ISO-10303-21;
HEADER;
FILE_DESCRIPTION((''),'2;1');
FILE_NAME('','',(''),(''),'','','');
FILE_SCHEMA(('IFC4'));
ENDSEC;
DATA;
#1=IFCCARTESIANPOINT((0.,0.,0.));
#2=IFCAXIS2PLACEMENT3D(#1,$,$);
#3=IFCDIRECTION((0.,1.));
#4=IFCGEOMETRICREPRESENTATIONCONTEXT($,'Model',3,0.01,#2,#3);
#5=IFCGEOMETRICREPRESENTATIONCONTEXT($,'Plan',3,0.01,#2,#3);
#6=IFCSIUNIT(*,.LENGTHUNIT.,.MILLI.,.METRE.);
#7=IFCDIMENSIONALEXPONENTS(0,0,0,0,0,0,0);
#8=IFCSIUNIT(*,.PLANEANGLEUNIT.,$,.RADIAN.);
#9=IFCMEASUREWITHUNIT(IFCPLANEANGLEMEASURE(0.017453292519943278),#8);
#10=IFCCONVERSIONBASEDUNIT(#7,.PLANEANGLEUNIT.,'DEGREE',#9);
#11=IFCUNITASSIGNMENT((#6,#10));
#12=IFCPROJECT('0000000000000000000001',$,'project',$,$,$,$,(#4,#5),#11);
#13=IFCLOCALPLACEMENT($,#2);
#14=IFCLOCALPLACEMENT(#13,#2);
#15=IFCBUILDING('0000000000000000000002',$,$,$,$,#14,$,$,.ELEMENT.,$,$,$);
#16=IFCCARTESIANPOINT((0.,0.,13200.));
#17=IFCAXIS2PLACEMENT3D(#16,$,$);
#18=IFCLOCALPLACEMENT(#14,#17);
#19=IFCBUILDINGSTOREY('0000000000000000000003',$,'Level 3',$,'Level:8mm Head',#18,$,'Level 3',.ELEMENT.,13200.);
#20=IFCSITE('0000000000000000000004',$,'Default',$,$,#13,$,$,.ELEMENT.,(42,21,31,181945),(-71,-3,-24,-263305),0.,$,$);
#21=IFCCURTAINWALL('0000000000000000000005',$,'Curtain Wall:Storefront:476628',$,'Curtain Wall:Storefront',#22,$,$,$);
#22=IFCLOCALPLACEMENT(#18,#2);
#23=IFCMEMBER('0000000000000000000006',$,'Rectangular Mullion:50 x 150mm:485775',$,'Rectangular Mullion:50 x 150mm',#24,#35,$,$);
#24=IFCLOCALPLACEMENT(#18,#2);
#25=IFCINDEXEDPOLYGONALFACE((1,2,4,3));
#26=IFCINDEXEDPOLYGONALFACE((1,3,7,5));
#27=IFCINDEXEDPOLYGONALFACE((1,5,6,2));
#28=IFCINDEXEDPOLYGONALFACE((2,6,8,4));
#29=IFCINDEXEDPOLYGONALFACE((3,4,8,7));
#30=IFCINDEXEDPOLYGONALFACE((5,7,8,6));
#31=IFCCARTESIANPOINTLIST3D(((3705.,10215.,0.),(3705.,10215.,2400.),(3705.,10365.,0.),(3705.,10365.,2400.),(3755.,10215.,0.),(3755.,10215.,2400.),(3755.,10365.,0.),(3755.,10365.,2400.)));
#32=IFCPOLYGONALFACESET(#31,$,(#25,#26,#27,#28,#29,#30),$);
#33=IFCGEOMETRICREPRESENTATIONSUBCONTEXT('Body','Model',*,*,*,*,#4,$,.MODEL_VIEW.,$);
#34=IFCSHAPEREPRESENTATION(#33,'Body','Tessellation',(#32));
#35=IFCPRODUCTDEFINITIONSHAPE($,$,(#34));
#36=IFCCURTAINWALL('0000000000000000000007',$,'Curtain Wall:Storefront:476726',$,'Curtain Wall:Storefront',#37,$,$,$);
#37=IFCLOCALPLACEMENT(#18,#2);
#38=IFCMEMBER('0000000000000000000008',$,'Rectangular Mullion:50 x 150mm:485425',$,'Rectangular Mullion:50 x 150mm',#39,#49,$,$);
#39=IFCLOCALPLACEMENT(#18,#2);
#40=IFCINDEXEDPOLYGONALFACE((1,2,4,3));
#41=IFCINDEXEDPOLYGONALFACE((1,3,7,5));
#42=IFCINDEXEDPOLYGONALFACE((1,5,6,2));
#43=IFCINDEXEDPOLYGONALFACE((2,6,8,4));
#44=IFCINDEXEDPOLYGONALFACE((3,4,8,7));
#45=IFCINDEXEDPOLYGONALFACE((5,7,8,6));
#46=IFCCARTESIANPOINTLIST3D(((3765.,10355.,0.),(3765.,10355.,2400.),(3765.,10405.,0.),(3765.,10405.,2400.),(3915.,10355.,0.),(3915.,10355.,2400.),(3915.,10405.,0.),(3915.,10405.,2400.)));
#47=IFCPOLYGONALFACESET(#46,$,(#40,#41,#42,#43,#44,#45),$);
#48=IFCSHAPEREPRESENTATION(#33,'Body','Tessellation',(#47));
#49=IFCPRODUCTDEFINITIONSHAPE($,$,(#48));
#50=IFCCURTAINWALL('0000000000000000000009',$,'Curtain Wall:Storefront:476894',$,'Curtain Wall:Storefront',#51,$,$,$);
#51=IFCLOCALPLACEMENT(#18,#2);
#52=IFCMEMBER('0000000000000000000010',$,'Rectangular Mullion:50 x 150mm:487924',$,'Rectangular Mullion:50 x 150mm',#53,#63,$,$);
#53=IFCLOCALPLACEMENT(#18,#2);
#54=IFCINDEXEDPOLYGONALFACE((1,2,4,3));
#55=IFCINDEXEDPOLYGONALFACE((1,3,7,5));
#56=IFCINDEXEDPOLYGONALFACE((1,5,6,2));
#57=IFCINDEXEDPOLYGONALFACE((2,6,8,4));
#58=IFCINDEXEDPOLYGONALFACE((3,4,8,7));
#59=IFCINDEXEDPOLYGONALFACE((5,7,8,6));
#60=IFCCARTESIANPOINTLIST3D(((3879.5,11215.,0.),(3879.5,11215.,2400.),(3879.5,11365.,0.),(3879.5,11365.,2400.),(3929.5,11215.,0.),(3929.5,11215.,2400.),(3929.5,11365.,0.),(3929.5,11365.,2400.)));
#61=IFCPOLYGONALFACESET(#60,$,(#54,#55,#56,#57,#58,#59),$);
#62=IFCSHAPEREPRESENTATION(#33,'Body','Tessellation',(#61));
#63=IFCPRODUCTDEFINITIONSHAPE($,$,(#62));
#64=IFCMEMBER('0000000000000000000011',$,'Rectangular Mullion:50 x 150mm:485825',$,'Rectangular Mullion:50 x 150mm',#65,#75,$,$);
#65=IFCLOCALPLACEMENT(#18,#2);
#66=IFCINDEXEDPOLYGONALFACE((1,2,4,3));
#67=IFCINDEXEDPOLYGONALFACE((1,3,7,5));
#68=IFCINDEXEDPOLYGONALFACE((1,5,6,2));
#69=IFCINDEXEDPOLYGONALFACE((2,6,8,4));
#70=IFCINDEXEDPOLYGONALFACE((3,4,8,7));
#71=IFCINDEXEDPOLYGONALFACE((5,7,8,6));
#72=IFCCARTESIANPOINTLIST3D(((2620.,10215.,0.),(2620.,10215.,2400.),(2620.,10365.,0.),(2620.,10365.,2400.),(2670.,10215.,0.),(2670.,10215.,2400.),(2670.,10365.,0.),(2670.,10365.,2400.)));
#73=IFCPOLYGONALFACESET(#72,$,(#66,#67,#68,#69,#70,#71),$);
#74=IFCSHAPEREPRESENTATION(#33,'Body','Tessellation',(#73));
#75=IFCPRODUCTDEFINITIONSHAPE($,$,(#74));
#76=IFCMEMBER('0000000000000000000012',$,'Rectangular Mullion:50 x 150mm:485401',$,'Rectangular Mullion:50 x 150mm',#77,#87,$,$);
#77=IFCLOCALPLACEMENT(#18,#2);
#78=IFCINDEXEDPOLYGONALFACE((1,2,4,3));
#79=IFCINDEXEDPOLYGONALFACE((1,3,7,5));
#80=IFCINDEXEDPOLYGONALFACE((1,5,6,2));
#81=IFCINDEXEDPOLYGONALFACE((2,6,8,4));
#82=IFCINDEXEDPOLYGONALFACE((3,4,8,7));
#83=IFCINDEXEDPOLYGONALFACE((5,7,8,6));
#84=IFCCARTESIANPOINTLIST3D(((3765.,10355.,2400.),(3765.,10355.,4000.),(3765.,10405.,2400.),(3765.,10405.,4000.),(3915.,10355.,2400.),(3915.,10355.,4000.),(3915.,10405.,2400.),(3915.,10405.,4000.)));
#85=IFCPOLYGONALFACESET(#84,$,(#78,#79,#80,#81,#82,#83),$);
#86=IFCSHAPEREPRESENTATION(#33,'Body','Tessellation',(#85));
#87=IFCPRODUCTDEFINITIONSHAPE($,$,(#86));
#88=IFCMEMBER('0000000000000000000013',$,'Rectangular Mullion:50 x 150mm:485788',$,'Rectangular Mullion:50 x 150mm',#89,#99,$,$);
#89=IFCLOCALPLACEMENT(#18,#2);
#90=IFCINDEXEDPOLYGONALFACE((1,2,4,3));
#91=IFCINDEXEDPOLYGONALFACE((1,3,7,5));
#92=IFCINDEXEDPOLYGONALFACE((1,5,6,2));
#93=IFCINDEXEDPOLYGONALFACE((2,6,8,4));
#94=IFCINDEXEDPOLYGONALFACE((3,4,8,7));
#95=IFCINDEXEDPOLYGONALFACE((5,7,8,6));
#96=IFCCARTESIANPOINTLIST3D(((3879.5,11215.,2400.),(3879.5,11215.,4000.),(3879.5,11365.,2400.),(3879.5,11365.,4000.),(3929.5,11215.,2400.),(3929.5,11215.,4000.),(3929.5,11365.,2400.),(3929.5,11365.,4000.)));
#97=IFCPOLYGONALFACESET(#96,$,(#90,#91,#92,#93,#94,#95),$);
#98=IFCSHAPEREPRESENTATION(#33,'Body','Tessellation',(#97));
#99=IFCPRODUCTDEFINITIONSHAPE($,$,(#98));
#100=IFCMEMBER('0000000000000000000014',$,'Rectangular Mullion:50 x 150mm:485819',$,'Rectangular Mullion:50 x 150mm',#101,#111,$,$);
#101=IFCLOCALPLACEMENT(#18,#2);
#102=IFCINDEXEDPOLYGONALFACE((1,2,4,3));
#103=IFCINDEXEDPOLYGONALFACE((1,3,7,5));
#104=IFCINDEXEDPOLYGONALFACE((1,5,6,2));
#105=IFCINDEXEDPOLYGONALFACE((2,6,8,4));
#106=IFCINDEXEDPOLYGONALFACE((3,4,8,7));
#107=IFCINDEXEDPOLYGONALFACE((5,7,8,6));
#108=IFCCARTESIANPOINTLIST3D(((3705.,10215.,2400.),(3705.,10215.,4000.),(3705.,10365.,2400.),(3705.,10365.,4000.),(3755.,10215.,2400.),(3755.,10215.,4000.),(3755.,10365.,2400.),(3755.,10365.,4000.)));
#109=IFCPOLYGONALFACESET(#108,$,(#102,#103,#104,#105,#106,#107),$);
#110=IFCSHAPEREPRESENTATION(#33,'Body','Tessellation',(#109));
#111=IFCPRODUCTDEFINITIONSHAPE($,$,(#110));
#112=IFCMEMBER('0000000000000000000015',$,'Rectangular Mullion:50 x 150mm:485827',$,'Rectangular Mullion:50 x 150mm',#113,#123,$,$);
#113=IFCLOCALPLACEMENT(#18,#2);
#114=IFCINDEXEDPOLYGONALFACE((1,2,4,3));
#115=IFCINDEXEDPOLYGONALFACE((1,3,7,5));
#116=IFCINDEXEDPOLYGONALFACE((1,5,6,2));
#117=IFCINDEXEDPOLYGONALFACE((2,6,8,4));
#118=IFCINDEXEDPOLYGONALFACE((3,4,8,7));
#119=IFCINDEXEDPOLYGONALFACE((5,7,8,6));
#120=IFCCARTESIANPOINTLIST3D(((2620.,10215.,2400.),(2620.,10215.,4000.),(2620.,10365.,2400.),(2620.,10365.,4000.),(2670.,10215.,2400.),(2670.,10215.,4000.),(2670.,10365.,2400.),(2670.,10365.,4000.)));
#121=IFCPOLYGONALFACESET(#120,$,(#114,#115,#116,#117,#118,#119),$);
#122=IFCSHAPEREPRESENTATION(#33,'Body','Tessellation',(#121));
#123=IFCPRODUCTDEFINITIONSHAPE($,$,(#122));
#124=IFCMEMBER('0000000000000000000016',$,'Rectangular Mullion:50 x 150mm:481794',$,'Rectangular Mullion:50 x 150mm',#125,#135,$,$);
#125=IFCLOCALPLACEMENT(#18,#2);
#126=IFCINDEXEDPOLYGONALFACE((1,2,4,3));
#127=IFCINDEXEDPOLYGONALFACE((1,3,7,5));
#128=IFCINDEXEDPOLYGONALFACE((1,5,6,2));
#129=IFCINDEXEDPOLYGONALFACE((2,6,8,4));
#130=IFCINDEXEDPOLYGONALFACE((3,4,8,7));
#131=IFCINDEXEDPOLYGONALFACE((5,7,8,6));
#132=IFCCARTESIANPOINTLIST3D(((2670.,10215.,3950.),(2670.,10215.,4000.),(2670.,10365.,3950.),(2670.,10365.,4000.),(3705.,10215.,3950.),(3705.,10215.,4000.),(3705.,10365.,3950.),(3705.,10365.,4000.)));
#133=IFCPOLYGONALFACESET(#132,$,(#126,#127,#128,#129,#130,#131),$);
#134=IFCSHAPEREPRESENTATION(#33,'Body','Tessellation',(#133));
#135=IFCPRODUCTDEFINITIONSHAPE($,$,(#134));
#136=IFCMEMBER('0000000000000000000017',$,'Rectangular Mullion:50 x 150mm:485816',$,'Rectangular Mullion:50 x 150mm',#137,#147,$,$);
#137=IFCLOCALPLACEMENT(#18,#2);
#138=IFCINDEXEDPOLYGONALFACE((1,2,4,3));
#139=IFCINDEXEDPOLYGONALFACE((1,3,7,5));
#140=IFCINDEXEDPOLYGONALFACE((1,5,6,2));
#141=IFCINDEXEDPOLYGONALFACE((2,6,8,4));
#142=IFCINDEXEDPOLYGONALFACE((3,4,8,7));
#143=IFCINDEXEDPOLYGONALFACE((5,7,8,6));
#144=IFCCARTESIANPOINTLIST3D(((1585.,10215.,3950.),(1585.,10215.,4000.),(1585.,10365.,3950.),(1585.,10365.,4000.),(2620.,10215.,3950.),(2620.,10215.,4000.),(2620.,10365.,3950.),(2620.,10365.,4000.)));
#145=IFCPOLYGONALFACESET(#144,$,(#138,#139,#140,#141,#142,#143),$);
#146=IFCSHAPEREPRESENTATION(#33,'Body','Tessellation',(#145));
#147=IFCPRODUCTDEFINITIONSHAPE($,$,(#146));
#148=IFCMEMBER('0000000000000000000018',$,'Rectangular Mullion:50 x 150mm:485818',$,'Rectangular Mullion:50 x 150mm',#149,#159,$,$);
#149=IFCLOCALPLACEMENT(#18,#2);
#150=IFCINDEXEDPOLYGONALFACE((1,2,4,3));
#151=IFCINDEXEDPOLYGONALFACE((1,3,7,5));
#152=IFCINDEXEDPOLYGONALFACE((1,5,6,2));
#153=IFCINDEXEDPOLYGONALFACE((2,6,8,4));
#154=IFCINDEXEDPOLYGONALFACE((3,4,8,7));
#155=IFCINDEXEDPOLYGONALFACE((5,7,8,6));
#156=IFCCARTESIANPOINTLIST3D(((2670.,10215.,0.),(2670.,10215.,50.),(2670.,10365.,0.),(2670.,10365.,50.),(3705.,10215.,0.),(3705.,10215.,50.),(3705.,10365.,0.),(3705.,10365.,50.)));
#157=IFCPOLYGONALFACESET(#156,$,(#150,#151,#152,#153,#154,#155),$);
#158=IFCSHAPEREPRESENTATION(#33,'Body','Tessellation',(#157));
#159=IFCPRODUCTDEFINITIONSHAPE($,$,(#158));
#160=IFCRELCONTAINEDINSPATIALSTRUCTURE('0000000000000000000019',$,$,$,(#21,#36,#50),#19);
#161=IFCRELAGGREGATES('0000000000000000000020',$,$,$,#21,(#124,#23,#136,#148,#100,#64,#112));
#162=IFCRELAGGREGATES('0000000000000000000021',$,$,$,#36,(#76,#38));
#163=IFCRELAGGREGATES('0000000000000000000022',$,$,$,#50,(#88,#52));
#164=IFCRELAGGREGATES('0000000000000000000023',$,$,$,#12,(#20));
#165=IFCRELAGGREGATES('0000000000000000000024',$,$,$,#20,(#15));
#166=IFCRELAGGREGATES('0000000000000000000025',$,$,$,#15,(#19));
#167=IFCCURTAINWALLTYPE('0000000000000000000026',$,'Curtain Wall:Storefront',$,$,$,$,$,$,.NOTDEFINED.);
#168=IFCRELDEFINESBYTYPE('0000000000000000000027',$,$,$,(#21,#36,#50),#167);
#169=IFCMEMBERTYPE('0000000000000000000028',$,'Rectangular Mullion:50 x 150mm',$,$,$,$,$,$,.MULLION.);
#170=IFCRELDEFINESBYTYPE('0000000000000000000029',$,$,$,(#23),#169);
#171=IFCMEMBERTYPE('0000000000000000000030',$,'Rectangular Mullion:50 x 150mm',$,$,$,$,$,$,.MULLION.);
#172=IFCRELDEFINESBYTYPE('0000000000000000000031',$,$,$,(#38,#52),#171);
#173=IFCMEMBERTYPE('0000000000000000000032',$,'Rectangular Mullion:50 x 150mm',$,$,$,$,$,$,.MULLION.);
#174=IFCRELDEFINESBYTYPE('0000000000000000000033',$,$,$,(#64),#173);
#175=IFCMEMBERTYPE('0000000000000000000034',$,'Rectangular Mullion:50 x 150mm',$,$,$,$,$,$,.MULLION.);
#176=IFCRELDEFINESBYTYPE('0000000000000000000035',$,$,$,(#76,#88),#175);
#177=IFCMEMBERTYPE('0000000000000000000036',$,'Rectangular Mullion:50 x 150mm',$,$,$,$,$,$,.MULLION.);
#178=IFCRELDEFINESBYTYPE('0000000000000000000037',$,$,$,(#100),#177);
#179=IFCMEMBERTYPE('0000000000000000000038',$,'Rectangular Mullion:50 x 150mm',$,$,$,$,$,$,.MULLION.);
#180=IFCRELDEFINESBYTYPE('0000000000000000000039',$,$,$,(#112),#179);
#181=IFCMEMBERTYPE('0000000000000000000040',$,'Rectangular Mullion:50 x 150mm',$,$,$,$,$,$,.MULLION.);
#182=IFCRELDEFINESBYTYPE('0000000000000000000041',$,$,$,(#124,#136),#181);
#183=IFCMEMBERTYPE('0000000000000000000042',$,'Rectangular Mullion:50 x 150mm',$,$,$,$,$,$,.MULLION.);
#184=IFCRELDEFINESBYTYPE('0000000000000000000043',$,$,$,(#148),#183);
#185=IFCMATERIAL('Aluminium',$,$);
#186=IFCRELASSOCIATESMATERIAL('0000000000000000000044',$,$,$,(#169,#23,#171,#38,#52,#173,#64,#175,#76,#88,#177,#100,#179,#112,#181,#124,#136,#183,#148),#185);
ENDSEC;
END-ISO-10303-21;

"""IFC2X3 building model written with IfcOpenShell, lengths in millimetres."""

from ifc_helpers import new_model, entity, si_unit, converted_unit, direction, frame, origin, origin_2d_with_axis, place, context, subcontext, project, spatial, rectangle, extrude, source, transform, mapped, material, type_object, type_shapes, element, aggregate, save


model = new_model("IFC2X3")

# Units and contexts
model_context = context("Model", 3, precision=0.01, world=origin(), true_north=direction((0.0, 1.0)))
plan_context = context("Plan", 3, precision=0.01, world=origin(), true_north=direction((0.0, 1.0)))
body_context = subcontext(model_context, "Body", "Model", "MODEL_VIEW")
ifc_project = project(units=[si_unit("LENGTHUNIT", "METRE", prefix="MILLI"), converted_unit("PLANEANGLEUNIT", "DEGREE", entity("IfcPlaneAngleMeasure", 0.017453292519943278), si_unit("PLANEANGLEUNIT", "RADIAN"), dimensions=[0, 0, 0, 0, 0, 0, 0])], contexts=[model_context, plan_context])

# Site, building, storey
site_placement = place(None, origin())
site = spatial("IfcSite", under=ifc_project, at=site_placement, Name="Default", CompositionType="ELEMENT", RefLatitude=(42, 21, 31, 181945), RefLongitude=(-71, -3, -24, -263305), RefElevation=0.0)
building_placement = place(site_placement, origin())
building = spatial("IfcBuilding", under=site, at=building_placement, CompositionType="ELEMENT")
storey_placement = place(building_placement, frame((0.0, 0.0, 13200.0)))
storey = spatial("IfcBuildingStorey", under=building, at=storey_placement, Name="Level 3", ObjectType="Level:8mm Head", LongName="Level 3", CompositionType="ELEMENT", Elevation=13200.0)

# Curtain walls, members
curtain_wall_type = type_object("IfcCurtainWallType", Name="Curtain Wall:Storefront", PredefinedType="NOTDEFINED")
curtain_wall_1_placement = place(storey_placement, frame((0.0, 0.0, -13200.0)))
curtain_wall_1 = element("IfcCurtainWall", 1, at=curtain_wall_1_placement, inside=storey, type_object=curtain_wall_type, Name="Curtain Wall:Storefront:476628", ObjectType="Curtain Wall:Storefront")
ifc_material_1 = material(Name="Aluminium")
member_type_1 = type_object("IfcMemberType", Name="Rectangular Mullion:50 x 150mm", PredefinedType="MULLION", material=ifc_material_1)
shared_shape_1 = source(origin(), body_context, "Body", "SweptSolid", [
    extrude(rectangle(XDim=50.0, YDim=150.0, at=origin_2d_with_axis()), frame((-25.0, 0.0, -2400.0), z_axis=(0.0, 0.0, 1.0), x_axis=(-1.0, 0.0, 0.0)), (0.0, 0.0, 1.0), 2400.0),
])
type_shapes(member_type_1, [shared_shape_1])
member_1_placement = place(curtain_wall_1_placement, frame((3755.0, 10290.0, 13200.0), z_axis=(0.0, 0.0, -1.0), x_axis=(1.0, 0.0, 0.0)))
member_1 = element("IfcMember", 2, at=member_1_placement, type_object=member_type_1, material=ifc_material_1, Name="Rectangular Mullion:50 x 150mm:485775", ObjectType="Rectangular Mullion:50 x 150mm", context=body_context, shape_type="MappedRepresentation", body=[
    mapped(shared_shape_1, transform((0.0, 0.0, 0.0), scale=1.0)),
])
curtain_wall_2_placement = place(storey_placement, frame((0.0, 0.0, -13200.0)))
curtain_wall_2 = element("IfcCurtainWall", 3, at=curtain_wall_2_placement, inside=storey, type_object=curtain_wall_type, Name="Curtain Wall:Storefront:476726", ObjectType="Curtain Wall:Storefront")
member_type_2 = type_object("IfcMemberType", Name="Rectangular Mullion:50 x 150mm", PredefinedType="MULLION", material=ifc_material_1)
shared_shape_2 = source(origin(), body_context, "Body", "SweptSolid", [
    extrude(rectangle(XDim=50.0, YDim=150.0, at=origin_2d_with_axis()), frame((-25.0, 0.0, -2400.0), z_axis=(0.0, 0.0, 1.0), x_axis=(-1.0, 0.0, 0.0)), (0.0, 0.0, 1.0), 2400.0),
])
type_shapes(member_type_2, [shared_shape_2])
member_2_placement = place(curtain_wall_2_placement, frame((3840.0, 10355.0, 15600.0), z_axis=(0.0, 0.0, 1.0), x_axis=(0.0, -1.0, 0.0)))
member_2 = element("IfcMember", 4, at=member_2_placement, type_object=member_type_2, material=ifc_material_1, Name="Rectangular Mullion:50 x 150mm:485425", ObjectType="Rectangular Mullion:50 x 150mm", context=body_context, shape_type="MappedRepresentation", body=[
    mapped(shared_shape_2, transform((0.0, 0.0, 0.0), scale=1.0)),
])
curtain_wall_3_placement = place(storey_placement, frame((0.0, 0.0, -13200.0)))
curtain_wall_3 = element("IfcCurtainWall", 5, at=curtain_wall_3_placement, inside=storey, type_object=curtain_wall_type, Name="Curtain Wall:Storefront:476894", ObjectType="Curtain Wall:Storefront")
member_3_placement = place(curtain_wall_3_placement, frame((3879.5, 11290.0, 15600.0), z_axis=(0.0, 0.0, 1.0), x_axis=(-1.0, 0.0, 0.0)))
member_3 = element("IfcMember", 6, at=member_3_placement, type_object=member_type_2, material=ifc_material_1, Name="Rectangular Mullion:50 x 150mm:487924", ObjectType="Rectangular Mullion:50 x 150mm", context=body_context, shape_type="MappedRepresentation", body=[
    mapped(shared_shape_2, transform((0.0, 0.0, 0.0), scale=1.0)),
])

# Members
member_type_3 = type_object("IfcMemberType", Name="Rectangular Mullion:50 x 150mm", PredefinedType="MULLION", material=ifc_material_1)
shared_shape_3 = source(origin(), body_context, "Body", "SweptSolid", [
    extrude(rectangle(XDim=50.0, YDim=150.0, at=origin_2d_with_axis()), frame((0.0, 0.0, -2400.0), z_axis=(0.0, 0.0, 1.0), x_axis=(-1.0, 0.0, 0.0)), (0.0, 0.0, 1.0), 2400.0),
])
type_shapes(member_type_3, [shared_shape_3])
member_4_placement = place(curtain_wall_1_placement, frame((2645.0, 10290.0, 13200.0), z_axis=(0.0, 0.0, -1.0), x_axis=(1.0, 0.0, 0.0)))
member_4 = element("IfcMember", 7, at=member_4_placement, type_object=member_type_3, material=ifc_material_1, Name="Rectangular Mullion:50 x 150mm:485825", ObjectType="Rectangular Mullion:50 x 150mm", context=body_context, shape_type="MappedRepresentation", body=[
    mapped(shared_shape_3, transform((0.0, 0.0, 0.0), scale=1.0)),
])
member_type_4 = type_object("IfcMemberType", Name="Rectangular Mullion:50 x 150mm", PredefinedType="MULLION", material=ifc_material_1)
shared_shape_4 = source(origin(), body_context, "Body", "SweptSolid", [
    extrude(rectangle(XDim=50.0, YDim=150.0, at=origin_2d_with_axis()), frame((-25.0, 0.0, -1600.0), z_axis=(0.0, 0.0, 1.0), x_axis=(-1.0, 0.0, 0.0)), (0.0, 0.0, 1.0), 1600.0),
])
type_shapes(member_type_4, [shared_shape_4])
member_5_placement = place(curtain_wall_2_placement, frame((3840.0, 10355.0, 17200.0), z_axis=(0.0, 0.0, 1.0), x_axis=(0.0, -1.0, 0.0)))
member_5 = element("IfcMember", 8, at=member_5_placement, type_object=member_type_4, material=ifc_material_1, Name="Rectangular Mullion:50 x 150mm:485401", ObjectType="Rectangular Mullion:50 x 150mm", context=body_context, shape_type="MappedRepresentation", body=[
    mapped(shared_shape_4, transform((0.0, 0.0, 0.0), scale=1.0)),
])
member_6_placement = place(curtain_wall_3_placement, frame((3879.5, 11290.0, 17200.0), z_axis=(0.0, 0.0, 1.0), x_axis=(-1.0, 0.0, 0.0)))
member_6 = element("IfcMember", 9, at=member_6_placement, type_object=member_type_4, material=ifc_material_1, Name="Rectangular Mullion:50 x 150mm:485788", ObjectType="Rectangular Mullion:50 x 150mm", context=body_context, shape_type="MappedRepresentation", body=[
    mapped(shared_shape_4, transform((0.0, 0.0, 0.0), scale=1.0)),
])
member_type_5 = type_object("IfcMemberType", Name="Rectangular Mullion:50 x 150mm", PredefinedType="MULLION", material=ifc_material_1)
shared_shape_5 = source(origin(), body_context, "Body", "SweptSolid", [
    extrude(rectangle(XDim=50.0, YDim=150.0, at=origin_2d_with_axis()), frame((-25.0, 0.0, -1600.0), z_axis=(0.0, 0.0, 1.0), x_axis=(-1.0, 0.0, 0.0)), (0.0, 0.0, 1.0), 1600.0),
])
type_shapes(member_type_5, [shared_shape_5])
member_7_placement = place(curtain_wall_1_placement, frame((3755.0, 10290.0, 15600.0), z_axis=(0.0, 0.0, -1.0), x_axis=(1.0, 0.0, 0.0)))
member_7 = element("IfcMember", 10, at=member_7_placement, type_object=member_type_5, material=ifc_material_1, Name="Rectangular Mullion:50 x 150mm:485819", ObjectType="Rectangular Mullion:50 x 150mm", context=body_context, shape_type="MappedRepresentation", body=[
    mapped(shared_shape_5, transform((0.0, 0.0, 0.0), scale=1.0)),
])
member_type_6 = type_object("IfcMemberType", Name="Rectangular Mullion:50 x 150mm", PredefinedType="MULLION", material=ifc_material_1)
shared_shape_6 = source(origin(), body_context, "Body", "SweptSolid", [
    extrude(rectangle(XDim=50.0, YDim=150.0, at=origin_2d_with_axis()), frame((0.0, 0.0, -1600.0), z_axis=(0.0, 0.0, 1.0), x_axis=(-1.0, 0.0, 0.0)), (0.0, 0.0, 1.0), 1600.0),
])
type_shapes(member_type_6, [shared_shape_6])
member_8_placement = place(curtain_wall_1_placement, frame((2645.0, 10290.0, 15600.0), z_axis=(0.0, 0.0, -1.0), x_axis=(1.0, 0.0, 0.0)))
member_8 = element("IfcMember", 11, at=member_8_placement, type_object=member_type_6, material=ifc_material_1, Name="Rectangular Mullion:50 x 150mm:485827", ObjectType="Rectangular Mullion:50 x 150mm", context=body_context, shape_type="MappedRepresentation", body=[
    mapped(shared_shape_6, transform((0.0, 0.0, 0.0), scale=1.0)),
])
member_type_7 = type_object("IfcMemberType", Name="Rectangular Mullion:50 x 150mm", PredefinedType="MULLION", material=ifc_material_1)
shared_shape_7 = source(origin(), body_context, "Body", "SweptSolid", [
    extrude(rectangle(XDim=50.0, YDim=150.0, at=origin_2d_with_axis()), frame((-25.0, 0.0, -1035.0), z_axis=(0.0, 0.0, 1.0), x_axis=(-1.0, 0.0, 0.0)), (0.0, 0.0, 1.0), 1035.0),
])
type_shapes(member_type_7, [shared_shape_7])
member_9_placement = place(curtain_wall_1_placement, frame((3705.0, 10290.0, 17200.0), z_axis=(1.0, 0.0, 0.0), x_axis=(0.0, 0.0, 1.0)))
member_9 = element("IfcMember", 12, at=member_9_placement, type_object=member_type_7, material=ifc_material_1, Name="Rectangular Mullion:50 x 150mm:481794", ObjectType="Rectangular Mullion:50 x 150mm", context=body_context, shape_type="MappedRepresentation", body=[
    mapped(shared_shape_7, transform((0.0, 0.0, 0.0), scale=1.0)),
])
member_10_placement = place(curtain_wall_1_placement, frame((2620.0, 10290.0, 17200.0), z_axis=(1.0, 0.0, 0.0), x_axis=(0.0, 0.0, 1.0)))
member_10 = element("IfcMember", 13, at=member_10_placement, type_object=member_type_7, material=ifc_material_1, Name="Rectangular Mullion:50 x 150mm:485816", ObjectType="Rectangular Mullion:50 x 150mm", context=body_context, shape_type="MappedRepresentation", body=[
    mapped(shared_shape_7, transform((0.0, 0.0, 0.0), scale=1.0)),
])
member_type_8 = type_object("IfcMemberType", Name="Rectangular Mullion:50 x 150mm", PredefinedType="MULLION", material=ifc_material_1)
shared_shape_8 = source(origin(), body_context, "Body", "SweptSolid", [
    extrude(rectangle(XDim=50.0, YDim=150.0, at=origin_2d_with_axis()), frame((-25.0, 0.0, -1035.0), z_axis=(0.0, 0.0, 1.0), x_axis=(-1.0, 0.0, 0.0)), (0.0, 0.0, 1.0), 1035.0),
])
type_shapes(member_type_8, [shared_shape_8])
member_11_placement = place(curtain_wall_1_placement, frame((2670.0, 10290.0, 13200.0), z_axis=(-1.0, 0.0, 0.0), x_axis=(0.0, 0.0, -1.0)))
member_11 = element("IfcMember", 14, at=member_11_placement, type_object=member_type_8, material=ifc_material_1, Name="Rectangular Mullion:50 x 150mm:485818", ObjectType="Rectangular Mullion:50 x 150mm", context=body_context, shape_type="MappedRepresentation", body=[
    mapped(shared_shape_8, transform((0.0, 0.0, 0.0), scale=1.0)),
])

aggregate(curtain_wall_1, [member_9, member_1, member_10, member_11, member_7, member_4, member_8])
aggregate(curtain_wall_2, [member_5, member_2])
aggregate(curtain_wall_3, [member_6, member_3])

save(model, "model.ifc")
